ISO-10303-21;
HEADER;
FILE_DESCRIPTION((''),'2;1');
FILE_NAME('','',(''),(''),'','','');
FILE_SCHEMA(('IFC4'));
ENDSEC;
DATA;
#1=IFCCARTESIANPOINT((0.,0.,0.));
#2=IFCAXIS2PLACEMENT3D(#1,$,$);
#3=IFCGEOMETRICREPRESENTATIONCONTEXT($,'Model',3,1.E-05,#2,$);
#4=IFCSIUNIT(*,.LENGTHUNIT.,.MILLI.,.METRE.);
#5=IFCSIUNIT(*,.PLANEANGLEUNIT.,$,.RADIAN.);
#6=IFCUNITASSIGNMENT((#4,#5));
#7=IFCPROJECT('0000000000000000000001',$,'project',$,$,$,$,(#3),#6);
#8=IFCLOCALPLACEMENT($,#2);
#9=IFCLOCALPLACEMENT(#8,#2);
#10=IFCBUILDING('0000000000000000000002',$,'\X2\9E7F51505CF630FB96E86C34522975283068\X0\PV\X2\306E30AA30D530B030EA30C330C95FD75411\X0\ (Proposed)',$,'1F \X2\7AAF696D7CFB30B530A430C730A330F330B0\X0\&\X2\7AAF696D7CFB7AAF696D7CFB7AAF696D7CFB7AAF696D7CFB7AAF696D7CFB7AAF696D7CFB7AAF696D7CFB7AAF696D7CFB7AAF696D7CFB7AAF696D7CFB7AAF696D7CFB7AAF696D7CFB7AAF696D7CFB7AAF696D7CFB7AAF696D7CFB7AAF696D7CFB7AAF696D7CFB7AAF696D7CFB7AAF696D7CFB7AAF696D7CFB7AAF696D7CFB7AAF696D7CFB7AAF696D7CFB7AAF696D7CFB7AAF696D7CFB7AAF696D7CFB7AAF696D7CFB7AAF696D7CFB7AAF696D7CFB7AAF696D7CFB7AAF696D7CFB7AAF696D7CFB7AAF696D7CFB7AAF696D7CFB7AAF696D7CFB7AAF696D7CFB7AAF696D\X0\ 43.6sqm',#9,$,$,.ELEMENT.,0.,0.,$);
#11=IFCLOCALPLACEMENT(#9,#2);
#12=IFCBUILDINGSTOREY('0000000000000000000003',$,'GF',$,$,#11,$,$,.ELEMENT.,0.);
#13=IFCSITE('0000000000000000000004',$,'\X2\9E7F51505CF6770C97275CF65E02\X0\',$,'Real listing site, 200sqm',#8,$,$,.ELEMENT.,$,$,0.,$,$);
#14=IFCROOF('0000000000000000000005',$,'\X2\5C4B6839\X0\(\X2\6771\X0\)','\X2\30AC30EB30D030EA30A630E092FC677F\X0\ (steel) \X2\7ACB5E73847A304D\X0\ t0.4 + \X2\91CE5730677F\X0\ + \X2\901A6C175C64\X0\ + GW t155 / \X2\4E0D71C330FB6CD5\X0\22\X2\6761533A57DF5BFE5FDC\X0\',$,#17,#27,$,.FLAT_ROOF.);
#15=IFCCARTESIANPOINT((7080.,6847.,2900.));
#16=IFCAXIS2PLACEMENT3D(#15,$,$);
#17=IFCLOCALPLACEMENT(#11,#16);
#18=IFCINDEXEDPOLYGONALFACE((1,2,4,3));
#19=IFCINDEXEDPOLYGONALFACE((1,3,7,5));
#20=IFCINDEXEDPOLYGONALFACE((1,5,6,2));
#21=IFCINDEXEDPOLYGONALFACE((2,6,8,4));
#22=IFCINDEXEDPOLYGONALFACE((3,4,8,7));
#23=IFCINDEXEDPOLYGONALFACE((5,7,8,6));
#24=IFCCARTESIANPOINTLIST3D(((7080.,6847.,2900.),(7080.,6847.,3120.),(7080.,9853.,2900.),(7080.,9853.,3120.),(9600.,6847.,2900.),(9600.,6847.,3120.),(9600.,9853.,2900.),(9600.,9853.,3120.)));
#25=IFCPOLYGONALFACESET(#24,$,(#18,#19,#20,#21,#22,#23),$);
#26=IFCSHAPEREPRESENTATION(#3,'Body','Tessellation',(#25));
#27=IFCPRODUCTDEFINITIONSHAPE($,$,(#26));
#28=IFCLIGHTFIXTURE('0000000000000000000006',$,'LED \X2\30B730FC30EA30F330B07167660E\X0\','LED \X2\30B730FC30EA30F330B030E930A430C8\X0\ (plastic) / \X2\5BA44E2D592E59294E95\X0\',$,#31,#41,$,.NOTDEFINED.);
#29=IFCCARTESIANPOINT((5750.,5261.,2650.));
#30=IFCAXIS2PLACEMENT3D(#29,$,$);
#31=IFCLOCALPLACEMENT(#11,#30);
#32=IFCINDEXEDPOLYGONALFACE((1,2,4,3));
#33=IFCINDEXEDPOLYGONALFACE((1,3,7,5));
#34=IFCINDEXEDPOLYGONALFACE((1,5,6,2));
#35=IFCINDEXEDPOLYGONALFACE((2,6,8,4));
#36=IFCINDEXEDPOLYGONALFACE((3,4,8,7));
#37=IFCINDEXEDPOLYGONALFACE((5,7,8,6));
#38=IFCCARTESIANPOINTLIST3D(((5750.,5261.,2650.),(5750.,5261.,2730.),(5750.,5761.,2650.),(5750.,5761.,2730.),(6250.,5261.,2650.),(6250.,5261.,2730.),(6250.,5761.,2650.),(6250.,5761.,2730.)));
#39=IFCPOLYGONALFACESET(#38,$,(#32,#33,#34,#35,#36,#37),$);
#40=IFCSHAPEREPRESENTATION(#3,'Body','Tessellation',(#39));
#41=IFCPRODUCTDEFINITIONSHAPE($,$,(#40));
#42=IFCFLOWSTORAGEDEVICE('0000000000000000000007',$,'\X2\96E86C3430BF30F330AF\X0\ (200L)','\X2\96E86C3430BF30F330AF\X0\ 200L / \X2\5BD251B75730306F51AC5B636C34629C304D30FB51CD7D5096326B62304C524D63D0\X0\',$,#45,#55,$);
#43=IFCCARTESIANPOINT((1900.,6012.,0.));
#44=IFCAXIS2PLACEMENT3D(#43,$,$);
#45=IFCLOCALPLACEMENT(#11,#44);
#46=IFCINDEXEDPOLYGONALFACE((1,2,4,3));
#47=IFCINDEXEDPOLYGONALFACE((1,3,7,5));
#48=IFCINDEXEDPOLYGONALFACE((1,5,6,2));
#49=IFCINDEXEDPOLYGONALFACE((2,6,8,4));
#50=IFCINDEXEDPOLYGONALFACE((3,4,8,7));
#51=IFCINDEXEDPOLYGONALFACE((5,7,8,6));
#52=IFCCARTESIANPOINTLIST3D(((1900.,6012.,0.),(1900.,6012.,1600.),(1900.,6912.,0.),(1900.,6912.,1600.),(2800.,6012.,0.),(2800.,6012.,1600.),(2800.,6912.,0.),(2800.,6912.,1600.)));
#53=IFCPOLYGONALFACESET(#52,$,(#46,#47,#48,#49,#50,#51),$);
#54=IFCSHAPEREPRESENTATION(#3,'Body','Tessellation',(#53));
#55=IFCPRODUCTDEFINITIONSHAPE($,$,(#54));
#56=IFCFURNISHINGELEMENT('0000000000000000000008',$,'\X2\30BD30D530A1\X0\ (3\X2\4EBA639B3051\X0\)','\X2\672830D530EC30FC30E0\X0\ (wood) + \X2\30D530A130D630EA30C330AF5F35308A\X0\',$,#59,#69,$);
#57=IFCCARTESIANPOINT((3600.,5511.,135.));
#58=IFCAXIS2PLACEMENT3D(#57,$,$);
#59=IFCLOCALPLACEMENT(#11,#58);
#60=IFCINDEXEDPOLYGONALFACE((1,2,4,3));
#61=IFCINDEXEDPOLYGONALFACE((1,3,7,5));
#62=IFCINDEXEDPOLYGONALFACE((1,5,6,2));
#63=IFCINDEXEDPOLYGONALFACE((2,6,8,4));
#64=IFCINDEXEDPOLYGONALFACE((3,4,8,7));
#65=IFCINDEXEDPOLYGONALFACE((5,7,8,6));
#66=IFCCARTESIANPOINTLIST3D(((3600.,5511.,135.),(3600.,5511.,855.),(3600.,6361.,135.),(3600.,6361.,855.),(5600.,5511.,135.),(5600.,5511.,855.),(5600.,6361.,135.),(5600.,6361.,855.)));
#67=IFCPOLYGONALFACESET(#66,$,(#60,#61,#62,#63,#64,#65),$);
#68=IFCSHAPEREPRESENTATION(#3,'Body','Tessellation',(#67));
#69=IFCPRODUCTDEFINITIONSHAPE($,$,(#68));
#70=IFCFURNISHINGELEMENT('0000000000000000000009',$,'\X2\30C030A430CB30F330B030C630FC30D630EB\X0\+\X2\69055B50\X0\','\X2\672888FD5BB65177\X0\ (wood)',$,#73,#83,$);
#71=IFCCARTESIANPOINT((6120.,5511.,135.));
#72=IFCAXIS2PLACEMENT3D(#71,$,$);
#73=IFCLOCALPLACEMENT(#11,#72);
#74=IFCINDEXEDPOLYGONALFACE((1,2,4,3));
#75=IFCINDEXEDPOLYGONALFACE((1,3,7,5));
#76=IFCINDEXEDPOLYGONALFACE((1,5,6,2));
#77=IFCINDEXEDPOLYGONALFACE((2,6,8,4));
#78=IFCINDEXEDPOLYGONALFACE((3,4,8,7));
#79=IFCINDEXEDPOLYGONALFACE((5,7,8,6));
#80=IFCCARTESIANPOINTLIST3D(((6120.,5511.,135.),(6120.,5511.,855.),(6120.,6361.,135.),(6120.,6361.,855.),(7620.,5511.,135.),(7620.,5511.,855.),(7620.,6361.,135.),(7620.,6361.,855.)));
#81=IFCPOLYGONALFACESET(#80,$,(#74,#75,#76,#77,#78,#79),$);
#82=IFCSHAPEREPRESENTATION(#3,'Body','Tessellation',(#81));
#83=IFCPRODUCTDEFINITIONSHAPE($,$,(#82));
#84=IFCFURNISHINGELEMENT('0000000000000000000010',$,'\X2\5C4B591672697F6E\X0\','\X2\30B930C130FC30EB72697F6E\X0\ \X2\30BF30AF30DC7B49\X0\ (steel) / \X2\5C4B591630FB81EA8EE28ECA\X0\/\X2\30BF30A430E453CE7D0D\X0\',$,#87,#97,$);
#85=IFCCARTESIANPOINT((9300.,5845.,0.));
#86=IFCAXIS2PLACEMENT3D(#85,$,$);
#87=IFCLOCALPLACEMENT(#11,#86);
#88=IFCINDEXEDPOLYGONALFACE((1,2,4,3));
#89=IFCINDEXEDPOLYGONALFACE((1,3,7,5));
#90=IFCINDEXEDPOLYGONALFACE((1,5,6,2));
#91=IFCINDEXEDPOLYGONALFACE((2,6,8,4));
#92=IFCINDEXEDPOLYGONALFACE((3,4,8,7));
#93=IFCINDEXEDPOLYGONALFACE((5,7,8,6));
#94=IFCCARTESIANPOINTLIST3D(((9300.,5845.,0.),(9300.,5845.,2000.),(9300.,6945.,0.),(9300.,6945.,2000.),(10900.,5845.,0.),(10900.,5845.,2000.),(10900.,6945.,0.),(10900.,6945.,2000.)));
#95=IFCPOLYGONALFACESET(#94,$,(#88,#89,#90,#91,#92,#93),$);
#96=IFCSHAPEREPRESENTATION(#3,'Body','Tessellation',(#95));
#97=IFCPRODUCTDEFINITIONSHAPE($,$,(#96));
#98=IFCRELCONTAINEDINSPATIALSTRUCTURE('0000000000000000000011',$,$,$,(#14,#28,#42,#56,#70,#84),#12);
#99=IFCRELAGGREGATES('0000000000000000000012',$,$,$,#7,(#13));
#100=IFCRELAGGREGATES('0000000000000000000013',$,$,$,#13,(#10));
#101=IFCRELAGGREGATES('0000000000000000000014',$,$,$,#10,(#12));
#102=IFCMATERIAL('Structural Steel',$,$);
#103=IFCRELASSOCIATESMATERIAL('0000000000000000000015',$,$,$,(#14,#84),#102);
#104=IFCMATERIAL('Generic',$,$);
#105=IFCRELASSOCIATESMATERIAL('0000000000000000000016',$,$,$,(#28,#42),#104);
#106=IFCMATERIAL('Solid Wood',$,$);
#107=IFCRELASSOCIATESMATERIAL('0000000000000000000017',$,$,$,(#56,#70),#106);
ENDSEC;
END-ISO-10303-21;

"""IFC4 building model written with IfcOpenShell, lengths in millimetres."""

from ifc_helpers import new_model, si_unit, frame, frame_2d, origin, place, context, project, spatial, rectangle, extrude, material, element, save


model = new_model("IFC4")

# Units and contexts
model_context = context("Model", 3, precision=1e-05, world=origin())
ifc_project = project(units=[si_unit("LENGTHUNIT", "METRE", prefix="MILLI"), si_unit("PLANEANGLEUNIT", "RADIAN")], contexts=[model_context])

# Site, building, storey
site_placement = place(None, origin())
site = spatial("IfcSite", under=ifc_project, at=site_placement, Name="鹿児島県霧島市", ObjectType="Real listing site, 200sqm", CompositionType="ELEMENT", RefElevation=0.0)
building_placement = place(site_placement, origin())
building = spatial("IfcBuilding", under=site, at=building_placement, Name="鹿児島・雨水利用とPVのオフグリッド志向 (Proposed)", ObjectType="1F 窯業系サイディング&窯業系窯業系窯業系窯業系窯業系窯業系窯業系窯業系窯業系窯業系窯業系窯業系窯業系窯業系窯業系窯業系窯業系窯業系窯業系窯業系窯業系窯業系窯業系窯業系窯業系窯業系窯業系窯業系窯業系窯業系窯業系窯業系窯業系窯業系窯業系窯業系窯業 43.6sqm", CompositionType="ELEMENT", ElevationOfRefHeight=0.0, ElevationOfTerrain=0.0)
storey_placement = place(building_placement, origin())
storey = spatial("IfcBuildingStorey", under=building, at=storey_placement, Name="GF", CompositionType="ELEMENT", Elevation=0.0)

# Shared definitions
ifc_material_1 = material(Name="Solid Wood")

# Roof
ifc_material_2 = material(Name="Structural Steel")
roof_1_placement = place(storey_placement, frame((7080.0, 6847.0, 2900.0)))
element("IfcRoof", 1, at=roof_1_placement, inside=storey, material=ifc_material_2, Name="屋根(東)", Description="ガルバリウム鋼板 (steel) 立平葺き t0.4 + 野地板 + 通気層 + GW t155 / 不燃・法22条区域対応", PredefinedType="FLAT_ROOF", context=model_context, shape_type="SweptSolid", body=[
    extrude(rectangle(XDim=2520.0, YDim=3006.0, at=frame_2d((1260.0, 1503.0))), frame((7080.0, 6847.0, 2900.0)), (0.0, 0.0, 1.0), 220.0),
])

# Light fixture
ifc_material_3 = material(Name="Generic")
light_fixture_placement = place(storey_placement, frame((5750.0, 5261.0, 2650.0)))
element("IfcLightFixture", 2, at=light_fixture_placement, inside=storey, material=ifc_material_3, Name="LED シーリング照明", Description="LED シーリングライト (plastic) / 室中央天井", PredefinedType="NOTDEFINED", context=model_context, shape_type="SweptSolid", body=[
    extrude(rectangle(XDim=500.0, YDim=500.0, at=frame_2d((250.0, 250.0))), frame((5750.0, 5261.0, 2650.0)), (0.0, 0.0, 1.0), 80.0),
])

# Flow storage device
flow_storage_device_placement = place(storey_placement, frame((1900.0, 6012.0, 0.0)))
element("IfcFlowStorageDevice", 3, at=flow_storage_device_placement, inside=storey, material=ifc_material_3, Name="雨水タンク (200L)", Description="雨水タンク 200L / 寒冷地は冬季水抜き・凍結防止が前提", context=model_context, shape_type="SweptSolid", body=[
    extrude(rectangle(XDim=900.0, YDim=900.0, at=frame_2d((450.0, 450.0))), frame((1900.0, 6012.0, 0.0)), (0.0, 0.0, 1.0), 1600.0),
])

# Furnishing elements
furnishing_1_placement = place(storey_placement, frame((3600.0, 5511.0, 135.0)))
element("IfcFurnishingElement", 4, at=furnishing_1_placement, inside=storey, material=ifc_material_1, Name="ソファ (3人掛け)", Description="木フレーム (wood) + ファブリック張り", context=model_context, shape_type="SweptSolid", body=[
    extrude(rectangle(XDim=2000.0, YDim=850.0, at=frame_2d((1000.0, 425.0))), frame((3600.0, 5511.0, 135.0)), (0.0, 0.0, 1.0), 720.0),
])
furnishing_2_placement = place(storey_placement, frame((6120.0, 5511.0, 135.0)))
element("IfcFurnishingElement", 5, at=furnishing_2_placement, inside=storey, material=ifc_material_1, Name="ダイニングテーブル+椅子", Description="木製家具 (wood)", context=model_context, shape_type="SweptSolid", body=[
    extrude(rectangle(XDim=1500.0, YDim=850.0, at=frame_2d((750.0, 425.0))), frame((6120.0, 5511.0, 135.0)), (0.0, 0.0, 1.0), 720.0),
])
furnishing_3_placement = place(storey_placement, frame((9300.0, 5845.0, 0.0)))
element("IfcFurnishingElement", 6, at=furnishing_3_placement, inside=storey, material=ifc_material_2, Name="屋外物置", Description="スチール物置 タクボ等 (steel) / 屋外・自転車/タイヤ収納", context=model_context, shape_type="SweptSolid", body=[
    extrude(rectangle(XDim=1600.0, YDim=1100.0, at=frame_2d((800.0, 550.0))), frame((9300.0, 5845.0, 0.0)), (0.0, 0.0, 1.0), 2000.0),
])

save(model, "model.ifc")
